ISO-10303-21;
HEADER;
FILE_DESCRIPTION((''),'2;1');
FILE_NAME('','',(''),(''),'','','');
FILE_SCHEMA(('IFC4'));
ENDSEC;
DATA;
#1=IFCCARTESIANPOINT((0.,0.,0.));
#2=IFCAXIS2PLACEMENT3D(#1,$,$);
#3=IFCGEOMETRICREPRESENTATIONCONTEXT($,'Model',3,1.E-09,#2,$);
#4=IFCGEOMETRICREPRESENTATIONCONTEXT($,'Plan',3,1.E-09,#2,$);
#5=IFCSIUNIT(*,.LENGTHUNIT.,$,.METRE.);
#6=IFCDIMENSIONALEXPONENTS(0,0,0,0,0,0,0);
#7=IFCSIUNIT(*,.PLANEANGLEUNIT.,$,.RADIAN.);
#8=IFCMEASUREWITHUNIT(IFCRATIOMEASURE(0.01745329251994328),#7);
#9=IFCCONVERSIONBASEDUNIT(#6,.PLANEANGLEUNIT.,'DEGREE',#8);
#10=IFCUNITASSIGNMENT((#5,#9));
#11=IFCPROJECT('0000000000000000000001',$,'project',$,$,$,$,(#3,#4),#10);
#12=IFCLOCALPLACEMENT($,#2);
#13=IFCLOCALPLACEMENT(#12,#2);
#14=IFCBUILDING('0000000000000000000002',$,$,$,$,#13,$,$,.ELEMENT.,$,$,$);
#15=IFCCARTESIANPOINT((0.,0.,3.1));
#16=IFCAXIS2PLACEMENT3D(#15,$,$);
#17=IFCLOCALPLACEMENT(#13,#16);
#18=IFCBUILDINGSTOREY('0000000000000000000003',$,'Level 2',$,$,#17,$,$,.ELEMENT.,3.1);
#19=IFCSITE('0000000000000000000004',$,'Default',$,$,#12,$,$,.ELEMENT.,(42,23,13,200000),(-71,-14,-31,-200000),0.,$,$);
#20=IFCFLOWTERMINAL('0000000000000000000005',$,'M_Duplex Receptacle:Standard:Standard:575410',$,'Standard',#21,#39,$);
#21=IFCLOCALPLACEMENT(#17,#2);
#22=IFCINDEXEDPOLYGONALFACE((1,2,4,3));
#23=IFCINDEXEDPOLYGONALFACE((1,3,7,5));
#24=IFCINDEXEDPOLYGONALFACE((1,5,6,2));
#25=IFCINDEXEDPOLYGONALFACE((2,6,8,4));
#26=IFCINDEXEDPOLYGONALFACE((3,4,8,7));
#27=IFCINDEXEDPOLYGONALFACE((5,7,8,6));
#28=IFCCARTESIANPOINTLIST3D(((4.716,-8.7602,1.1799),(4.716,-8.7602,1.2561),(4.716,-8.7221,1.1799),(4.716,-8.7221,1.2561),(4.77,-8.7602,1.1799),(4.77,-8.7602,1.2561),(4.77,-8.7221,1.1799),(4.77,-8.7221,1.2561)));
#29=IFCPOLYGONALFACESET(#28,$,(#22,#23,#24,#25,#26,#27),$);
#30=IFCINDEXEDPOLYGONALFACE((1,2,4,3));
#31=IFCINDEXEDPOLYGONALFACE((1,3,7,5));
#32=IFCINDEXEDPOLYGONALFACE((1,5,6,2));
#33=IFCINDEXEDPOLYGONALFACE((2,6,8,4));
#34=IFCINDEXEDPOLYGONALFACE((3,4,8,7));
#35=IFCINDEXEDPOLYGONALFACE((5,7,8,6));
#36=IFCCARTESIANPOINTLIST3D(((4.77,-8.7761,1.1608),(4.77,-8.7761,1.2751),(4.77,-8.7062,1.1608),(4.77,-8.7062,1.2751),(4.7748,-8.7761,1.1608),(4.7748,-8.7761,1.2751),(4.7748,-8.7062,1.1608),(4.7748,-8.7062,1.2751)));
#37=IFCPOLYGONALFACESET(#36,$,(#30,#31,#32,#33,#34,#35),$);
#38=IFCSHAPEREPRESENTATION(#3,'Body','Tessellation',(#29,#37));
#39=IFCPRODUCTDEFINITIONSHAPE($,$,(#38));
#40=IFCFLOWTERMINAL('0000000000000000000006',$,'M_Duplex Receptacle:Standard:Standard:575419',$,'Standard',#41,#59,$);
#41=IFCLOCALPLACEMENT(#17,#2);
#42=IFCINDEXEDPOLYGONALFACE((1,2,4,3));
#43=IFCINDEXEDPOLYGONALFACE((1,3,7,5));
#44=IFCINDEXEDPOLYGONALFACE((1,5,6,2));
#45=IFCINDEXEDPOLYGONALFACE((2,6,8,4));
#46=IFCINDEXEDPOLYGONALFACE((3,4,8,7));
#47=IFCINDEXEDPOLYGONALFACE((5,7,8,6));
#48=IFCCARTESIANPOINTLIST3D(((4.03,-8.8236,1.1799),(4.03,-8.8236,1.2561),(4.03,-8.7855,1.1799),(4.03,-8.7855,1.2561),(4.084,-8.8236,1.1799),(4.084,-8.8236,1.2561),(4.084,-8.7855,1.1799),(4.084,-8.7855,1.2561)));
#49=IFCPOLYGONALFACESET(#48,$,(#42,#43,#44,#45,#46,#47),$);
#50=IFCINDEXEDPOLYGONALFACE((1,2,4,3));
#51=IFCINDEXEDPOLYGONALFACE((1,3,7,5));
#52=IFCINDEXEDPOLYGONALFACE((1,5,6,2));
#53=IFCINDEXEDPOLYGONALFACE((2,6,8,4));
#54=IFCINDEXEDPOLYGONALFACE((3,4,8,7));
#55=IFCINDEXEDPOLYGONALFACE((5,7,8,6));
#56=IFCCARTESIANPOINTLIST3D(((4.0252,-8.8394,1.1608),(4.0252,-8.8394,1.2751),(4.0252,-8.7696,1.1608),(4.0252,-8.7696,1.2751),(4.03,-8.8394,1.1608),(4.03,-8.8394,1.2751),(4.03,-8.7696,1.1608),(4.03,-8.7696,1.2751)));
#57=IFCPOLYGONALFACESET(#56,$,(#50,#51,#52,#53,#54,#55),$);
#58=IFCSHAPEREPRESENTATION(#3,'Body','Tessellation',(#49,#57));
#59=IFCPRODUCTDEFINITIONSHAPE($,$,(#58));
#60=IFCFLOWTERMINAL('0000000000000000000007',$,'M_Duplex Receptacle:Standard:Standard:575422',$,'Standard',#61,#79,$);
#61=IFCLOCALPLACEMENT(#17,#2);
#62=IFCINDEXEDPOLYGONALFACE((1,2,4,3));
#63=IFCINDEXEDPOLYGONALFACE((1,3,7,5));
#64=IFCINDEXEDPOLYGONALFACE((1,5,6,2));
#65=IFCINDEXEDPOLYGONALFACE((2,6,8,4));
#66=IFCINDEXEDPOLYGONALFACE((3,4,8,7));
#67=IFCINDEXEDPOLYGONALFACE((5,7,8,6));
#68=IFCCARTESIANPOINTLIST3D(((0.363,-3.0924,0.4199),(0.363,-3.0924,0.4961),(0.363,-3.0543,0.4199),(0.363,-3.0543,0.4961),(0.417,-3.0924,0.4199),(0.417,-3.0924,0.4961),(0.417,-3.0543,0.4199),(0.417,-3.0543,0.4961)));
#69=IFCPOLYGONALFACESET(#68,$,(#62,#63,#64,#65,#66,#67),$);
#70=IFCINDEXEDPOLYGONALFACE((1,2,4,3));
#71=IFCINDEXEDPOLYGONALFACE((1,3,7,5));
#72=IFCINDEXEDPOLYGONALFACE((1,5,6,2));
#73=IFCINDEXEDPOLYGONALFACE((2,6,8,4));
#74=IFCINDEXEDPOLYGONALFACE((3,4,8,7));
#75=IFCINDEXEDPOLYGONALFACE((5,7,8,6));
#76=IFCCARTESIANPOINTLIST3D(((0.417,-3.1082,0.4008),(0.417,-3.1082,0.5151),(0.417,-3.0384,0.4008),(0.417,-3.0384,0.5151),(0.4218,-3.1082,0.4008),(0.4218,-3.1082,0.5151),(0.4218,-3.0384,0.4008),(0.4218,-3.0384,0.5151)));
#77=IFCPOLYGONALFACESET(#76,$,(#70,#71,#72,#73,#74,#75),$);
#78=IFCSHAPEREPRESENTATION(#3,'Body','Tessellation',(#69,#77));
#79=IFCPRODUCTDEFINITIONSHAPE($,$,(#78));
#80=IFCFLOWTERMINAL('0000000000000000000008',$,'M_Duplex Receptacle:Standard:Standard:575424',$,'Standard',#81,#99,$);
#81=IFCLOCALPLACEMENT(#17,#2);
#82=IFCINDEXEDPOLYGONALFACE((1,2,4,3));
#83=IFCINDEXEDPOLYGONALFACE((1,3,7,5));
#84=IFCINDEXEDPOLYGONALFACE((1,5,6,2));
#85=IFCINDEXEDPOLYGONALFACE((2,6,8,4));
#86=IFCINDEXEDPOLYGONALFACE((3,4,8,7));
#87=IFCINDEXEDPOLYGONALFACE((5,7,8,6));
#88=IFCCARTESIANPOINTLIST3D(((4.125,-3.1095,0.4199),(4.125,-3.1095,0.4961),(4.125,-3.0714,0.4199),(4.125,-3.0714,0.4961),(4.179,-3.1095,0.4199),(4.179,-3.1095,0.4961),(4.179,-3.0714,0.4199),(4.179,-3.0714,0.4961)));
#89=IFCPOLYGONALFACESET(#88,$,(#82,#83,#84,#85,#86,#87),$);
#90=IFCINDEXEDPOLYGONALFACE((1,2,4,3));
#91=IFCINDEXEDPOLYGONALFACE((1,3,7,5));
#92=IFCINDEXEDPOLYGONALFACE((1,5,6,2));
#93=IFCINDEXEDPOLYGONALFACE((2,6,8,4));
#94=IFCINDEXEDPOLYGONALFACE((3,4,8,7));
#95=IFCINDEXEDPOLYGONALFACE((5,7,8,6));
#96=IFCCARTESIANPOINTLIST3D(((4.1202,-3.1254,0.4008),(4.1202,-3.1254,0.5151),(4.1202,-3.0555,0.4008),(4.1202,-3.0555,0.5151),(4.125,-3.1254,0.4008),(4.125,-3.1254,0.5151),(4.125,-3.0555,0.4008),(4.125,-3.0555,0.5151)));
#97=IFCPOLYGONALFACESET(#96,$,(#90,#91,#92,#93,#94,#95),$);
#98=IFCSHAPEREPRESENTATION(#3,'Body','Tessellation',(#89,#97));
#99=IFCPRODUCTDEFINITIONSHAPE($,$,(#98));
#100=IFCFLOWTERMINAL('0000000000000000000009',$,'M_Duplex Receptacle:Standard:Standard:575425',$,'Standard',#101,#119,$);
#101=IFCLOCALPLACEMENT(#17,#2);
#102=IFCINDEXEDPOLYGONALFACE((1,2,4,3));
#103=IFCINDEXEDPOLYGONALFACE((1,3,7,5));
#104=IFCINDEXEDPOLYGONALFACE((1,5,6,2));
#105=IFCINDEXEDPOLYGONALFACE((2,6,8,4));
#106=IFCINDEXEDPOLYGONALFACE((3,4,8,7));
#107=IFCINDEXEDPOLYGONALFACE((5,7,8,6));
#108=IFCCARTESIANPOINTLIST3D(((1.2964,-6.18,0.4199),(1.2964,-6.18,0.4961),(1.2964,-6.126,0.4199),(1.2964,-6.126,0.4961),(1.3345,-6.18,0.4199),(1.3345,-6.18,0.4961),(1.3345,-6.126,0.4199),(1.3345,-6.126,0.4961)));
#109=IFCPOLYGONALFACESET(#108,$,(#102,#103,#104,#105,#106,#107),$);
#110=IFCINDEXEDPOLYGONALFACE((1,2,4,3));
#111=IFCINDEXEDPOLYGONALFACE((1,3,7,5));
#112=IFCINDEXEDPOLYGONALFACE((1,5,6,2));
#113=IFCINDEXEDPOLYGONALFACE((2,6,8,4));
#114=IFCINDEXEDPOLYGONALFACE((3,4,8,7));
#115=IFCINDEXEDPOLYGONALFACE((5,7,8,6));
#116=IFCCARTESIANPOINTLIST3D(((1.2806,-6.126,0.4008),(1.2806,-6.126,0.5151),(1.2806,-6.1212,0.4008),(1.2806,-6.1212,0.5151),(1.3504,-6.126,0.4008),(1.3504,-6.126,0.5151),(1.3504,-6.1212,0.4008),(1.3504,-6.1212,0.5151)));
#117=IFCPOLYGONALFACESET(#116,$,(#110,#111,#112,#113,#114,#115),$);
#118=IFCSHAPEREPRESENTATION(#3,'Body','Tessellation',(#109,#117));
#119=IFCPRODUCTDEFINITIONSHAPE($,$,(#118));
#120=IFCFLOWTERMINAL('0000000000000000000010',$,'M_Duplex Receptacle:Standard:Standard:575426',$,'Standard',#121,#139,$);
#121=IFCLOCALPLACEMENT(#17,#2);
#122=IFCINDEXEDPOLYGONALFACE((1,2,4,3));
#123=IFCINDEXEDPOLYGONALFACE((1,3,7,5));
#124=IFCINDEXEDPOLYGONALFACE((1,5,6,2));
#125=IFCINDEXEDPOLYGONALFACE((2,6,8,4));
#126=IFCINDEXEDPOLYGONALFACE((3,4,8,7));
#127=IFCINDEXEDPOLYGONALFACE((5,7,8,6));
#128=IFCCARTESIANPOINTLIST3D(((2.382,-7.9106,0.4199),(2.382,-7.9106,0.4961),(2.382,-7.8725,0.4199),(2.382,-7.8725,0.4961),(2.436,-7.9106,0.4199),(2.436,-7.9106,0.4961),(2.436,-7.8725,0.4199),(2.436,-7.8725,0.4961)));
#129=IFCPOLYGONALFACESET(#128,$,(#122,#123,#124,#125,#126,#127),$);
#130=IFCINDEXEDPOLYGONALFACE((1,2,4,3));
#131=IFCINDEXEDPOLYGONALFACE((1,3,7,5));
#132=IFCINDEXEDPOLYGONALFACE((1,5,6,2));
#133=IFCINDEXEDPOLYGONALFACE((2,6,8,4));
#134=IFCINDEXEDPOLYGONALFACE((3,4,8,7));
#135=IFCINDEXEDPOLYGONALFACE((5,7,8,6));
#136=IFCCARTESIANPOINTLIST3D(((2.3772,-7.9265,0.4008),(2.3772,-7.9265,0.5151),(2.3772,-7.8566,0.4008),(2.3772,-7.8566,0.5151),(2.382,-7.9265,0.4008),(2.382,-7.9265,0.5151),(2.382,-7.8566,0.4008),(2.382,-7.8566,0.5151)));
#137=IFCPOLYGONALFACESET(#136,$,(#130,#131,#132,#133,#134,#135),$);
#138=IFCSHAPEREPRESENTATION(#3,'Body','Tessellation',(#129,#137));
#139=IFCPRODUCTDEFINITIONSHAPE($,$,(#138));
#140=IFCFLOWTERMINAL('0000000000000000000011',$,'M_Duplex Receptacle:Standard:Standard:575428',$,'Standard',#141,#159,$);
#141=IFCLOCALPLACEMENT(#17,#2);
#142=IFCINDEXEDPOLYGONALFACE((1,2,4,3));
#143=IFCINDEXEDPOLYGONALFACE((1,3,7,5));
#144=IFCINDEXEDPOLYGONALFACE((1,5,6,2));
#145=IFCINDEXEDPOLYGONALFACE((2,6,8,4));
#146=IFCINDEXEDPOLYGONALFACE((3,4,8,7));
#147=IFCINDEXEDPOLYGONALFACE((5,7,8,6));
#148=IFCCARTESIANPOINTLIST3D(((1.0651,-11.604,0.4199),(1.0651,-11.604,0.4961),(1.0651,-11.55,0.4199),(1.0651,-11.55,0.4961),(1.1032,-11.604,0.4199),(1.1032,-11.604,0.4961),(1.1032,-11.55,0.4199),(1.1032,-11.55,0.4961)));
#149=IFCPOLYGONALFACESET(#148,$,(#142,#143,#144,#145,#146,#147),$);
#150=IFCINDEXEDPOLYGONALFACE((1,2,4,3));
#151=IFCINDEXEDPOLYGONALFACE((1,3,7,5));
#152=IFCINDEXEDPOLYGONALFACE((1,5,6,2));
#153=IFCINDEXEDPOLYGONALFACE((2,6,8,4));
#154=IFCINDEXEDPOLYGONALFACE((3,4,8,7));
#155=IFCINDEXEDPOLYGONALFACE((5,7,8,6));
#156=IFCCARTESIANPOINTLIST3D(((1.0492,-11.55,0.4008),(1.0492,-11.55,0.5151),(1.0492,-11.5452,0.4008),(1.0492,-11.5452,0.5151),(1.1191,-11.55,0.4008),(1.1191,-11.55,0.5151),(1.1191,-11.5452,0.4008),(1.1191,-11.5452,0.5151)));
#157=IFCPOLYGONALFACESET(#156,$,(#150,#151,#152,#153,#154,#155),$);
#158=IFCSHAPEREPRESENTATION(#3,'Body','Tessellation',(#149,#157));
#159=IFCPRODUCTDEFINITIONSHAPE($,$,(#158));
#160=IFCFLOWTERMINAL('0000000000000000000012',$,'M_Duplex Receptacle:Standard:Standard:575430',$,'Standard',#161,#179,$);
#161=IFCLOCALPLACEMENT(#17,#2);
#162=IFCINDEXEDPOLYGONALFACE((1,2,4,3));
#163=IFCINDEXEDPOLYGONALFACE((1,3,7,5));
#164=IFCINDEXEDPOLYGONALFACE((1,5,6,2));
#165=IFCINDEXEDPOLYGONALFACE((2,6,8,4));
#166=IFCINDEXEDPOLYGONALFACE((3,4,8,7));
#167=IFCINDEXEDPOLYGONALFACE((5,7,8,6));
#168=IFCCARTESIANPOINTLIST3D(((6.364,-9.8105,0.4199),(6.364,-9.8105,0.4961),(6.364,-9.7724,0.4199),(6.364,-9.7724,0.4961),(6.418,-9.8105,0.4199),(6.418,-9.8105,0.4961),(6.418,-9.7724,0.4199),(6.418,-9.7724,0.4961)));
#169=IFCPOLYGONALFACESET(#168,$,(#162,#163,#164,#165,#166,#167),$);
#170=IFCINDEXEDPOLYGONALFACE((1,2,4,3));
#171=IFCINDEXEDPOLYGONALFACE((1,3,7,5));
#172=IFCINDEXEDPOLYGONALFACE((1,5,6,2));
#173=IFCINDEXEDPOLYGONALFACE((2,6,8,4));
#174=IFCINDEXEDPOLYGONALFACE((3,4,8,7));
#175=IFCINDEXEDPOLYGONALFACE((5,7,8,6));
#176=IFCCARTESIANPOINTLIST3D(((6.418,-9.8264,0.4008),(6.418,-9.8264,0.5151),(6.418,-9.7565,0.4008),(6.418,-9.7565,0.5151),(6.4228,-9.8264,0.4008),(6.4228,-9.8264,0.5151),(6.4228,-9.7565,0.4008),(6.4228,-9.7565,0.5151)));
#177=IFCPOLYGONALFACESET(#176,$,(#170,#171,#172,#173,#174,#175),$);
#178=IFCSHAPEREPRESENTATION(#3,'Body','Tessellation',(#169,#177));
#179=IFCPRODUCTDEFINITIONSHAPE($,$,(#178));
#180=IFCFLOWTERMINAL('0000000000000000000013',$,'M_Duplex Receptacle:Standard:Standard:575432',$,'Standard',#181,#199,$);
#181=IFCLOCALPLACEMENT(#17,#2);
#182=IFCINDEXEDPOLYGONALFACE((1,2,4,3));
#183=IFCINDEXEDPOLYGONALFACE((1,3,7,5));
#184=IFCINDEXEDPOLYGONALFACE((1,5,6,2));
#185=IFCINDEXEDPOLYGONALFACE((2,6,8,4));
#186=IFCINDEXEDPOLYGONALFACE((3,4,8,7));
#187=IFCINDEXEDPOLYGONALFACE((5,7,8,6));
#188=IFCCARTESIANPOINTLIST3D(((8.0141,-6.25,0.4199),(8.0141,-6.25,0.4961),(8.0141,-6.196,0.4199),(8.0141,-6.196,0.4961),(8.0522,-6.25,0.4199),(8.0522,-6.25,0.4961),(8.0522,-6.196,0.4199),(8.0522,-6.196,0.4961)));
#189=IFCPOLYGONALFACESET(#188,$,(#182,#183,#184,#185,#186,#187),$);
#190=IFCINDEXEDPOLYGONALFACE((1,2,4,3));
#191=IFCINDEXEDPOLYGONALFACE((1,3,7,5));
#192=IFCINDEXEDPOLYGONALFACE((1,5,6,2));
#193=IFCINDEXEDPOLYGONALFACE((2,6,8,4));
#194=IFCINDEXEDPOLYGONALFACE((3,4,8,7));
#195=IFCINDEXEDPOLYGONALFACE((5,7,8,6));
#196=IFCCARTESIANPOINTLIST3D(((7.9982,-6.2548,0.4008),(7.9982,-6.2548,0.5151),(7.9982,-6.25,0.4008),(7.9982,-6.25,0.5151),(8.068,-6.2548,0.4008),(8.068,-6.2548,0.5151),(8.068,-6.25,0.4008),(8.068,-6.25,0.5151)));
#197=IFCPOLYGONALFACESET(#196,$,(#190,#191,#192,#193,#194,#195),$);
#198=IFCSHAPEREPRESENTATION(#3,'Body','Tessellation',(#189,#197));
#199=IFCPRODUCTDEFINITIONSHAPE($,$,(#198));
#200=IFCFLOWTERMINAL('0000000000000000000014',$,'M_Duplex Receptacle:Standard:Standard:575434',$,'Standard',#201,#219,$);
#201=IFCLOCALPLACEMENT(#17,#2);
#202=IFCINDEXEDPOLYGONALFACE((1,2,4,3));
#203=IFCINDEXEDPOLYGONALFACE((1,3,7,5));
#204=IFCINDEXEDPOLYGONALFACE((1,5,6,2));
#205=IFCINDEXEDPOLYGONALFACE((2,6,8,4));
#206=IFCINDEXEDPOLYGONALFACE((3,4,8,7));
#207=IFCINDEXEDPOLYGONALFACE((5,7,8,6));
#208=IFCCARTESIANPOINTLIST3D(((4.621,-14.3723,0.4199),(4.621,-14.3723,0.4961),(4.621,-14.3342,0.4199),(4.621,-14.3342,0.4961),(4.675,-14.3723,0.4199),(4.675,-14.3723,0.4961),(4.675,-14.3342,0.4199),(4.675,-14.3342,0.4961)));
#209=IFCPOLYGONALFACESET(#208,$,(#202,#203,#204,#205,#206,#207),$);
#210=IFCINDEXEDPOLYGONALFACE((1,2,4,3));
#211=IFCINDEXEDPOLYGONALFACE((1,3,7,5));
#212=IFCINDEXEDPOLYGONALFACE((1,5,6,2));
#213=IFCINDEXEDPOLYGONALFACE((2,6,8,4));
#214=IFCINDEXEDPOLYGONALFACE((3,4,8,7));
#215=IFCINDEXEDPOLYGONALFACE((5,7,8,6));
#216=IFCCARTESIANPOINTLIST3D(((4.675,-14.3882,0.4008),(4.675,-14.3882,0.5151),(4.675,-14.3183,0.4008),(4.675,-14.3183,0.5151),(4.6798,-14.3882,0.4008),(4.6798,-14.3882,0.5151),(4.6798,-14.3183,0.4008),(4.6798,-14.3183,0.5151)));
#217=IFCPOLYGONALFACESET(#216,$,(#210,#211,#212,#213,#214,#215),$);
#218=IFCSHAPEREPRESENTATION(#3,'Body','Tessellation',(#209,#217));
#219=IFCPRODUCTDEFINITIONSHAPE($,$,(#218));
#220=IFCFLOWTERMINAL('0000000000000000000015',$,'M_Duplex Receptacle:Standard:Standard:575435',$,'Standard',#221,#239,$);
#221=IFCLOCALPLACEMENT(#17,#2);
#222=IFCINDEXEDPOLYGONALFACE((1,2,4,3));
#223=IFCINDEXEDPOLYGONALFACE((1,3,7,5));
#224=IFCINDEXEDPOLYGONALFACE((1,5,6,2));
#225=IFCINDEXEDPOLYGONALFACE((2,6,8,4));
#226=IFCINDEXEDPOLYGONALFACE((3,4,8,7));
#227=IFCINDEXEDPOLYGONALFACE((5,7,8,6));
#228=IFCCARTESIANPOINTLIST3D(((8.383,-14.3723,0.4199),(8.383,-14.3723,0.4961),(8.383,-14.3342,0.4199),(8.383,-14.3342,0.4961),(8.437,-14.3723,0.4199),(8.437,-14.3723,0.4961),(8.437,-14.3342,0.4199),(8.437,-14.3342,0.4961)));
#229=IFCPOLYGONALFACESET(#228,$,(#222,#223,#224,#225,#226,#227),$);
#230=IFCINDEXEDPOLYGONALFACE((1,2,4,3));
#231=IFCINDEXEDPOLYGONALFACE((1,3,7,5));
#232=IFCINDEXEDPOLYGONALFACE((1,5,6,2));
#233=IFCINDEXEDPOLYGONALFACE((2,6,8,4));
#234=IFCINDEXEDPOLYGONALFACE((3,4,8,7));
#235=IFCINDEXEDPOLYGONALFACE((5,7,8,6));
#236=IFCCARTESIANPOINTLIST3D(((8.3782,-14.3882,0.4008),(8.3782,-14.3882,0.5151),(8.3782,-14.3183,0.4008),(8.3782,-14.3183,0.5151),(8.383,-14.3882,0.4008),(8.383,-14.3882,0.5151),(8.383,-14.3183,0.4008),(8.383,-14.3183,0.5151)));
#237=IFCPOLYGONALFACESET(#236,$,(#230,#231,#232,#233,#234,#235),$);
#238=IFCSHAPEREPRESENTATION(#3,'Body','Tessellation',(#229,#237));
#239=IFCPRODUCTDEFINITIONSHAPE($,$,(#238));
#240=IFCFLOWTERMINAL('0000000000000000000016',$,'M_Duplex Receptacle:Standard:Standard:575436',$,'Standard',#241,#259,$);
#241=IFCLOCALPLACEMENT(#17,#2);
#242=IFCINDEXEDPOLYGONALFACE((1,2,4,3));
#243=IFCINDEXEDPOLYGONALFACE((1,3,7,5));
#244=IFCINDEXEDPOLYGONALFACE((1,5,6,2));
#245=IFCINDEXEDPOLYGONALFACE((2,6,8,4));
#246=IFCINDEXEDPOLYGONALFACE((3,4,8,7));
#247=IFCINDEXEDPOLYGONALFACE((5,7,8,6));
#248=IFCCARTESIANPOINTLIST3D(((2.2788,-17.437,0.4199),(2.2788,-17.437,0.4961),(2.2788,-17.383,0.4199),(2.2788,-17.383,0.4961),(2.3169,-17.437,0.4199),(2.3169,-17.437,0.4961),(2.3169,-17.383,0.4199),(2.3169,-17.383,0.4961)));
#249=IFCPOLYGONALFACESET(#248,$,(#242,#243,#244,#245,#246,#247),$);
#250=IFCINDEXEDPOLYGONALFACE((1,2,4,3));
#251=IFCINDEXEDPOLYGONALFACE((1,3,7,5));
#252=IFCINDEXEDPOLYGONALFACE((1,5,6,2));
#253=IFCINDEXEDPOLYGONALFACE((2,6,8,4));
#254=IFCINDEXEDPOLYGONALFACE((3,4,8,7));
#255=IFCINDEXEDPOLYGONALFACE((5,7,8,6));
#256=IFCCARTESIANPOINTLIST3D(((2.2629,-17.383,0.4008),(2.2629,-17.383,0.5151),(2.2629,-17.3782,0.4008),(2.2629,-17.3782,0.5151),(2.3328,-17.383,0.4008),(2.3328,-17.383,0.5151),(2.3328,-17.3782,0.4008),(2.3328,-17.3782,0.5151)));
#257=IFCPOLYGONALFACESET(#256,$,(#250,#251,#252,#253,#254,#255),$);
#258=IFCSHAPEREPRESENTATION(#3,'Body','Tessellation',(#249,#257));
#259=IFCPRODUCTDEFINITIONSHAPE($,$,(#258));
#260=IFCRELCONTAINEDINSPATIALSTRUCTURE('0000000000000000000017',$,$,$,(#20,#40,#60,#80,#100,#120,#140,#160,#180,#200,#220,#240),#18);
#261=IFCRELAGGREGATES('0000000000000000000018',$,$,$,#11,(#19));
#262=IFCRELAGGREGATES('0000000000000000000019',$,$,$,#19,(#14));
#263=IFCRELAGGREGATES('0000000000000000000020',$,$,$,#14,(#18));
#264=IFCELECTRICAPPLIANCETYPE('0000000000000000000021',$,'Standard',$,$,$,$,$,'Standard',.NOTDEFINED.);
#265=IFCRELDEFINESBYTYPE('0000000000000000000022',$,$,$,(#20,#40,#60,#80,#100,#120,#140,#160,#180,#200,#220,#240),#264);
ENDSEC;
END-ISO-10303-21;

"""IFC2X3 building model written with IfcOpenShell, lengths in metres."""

from ifc_helpers import new_model, entity, si_unit, converted_unit, frame, origin, origin_2d_with_axis, place, context, project, spatial, rectangle, extrude, source, transform, mapped, type_object, type_shapes, element, save


model = new_model("IFC2X3")

# Units and contexts
model_context = context("Model", 3, precision=1e-09, world=origin())
plan_context = context("Plan", 3, precision=1e-09, world=origin())
ifc_project = project(units=[si_unit("LENGTHUNIT", "METRE"), converted_unit("PLANEANGLEUNIT", "DEGREE", entity("IfcRatioMeasure", 0.01745329251994328), si_unit("PLANEANGLEUNIT", "RADIAN"), dimensions=[0, 0, 0, 0, 0, 0, 0])], contexts=[model_context, plan_context])

# Site, building, storey
site_placement = place(None, origin())
site = spatial("IfcSite", under=ifc_project, at=site_placement, Name="Default", CompositionType="ELEMENT", RefLatitude=(42, 23, 13, 200000), RefLongitude=(-71, -14, -31, -200000), RefElevation=0.0)
building_placement = place(site_placement, origin())
building = spatial("IfcBuilding", under=site, at=building_placement, CompositionType="ELEMENT")
storey_placement = place(building_placement, frame((0.0, 0.0, 3.1)))
storey = spatial("IfcBuildingStorey", under=building, at=storey_placement, Name="Level 2", CompositionType="ELEMENT", Elevation=3.1)

# Flow terminals
electric_appliance_type_1 = type_object("IfcElectricApplianceType", Name="Standard", ElementType="Standard", PredefinedType="NOTDEFINED")
shared_shape_1 = source(origin(), model_context, "Body", "SweptSolid", [
    extrude(rectangle(XDim=0.0381, YDim=0.0762, at=origin_2d_with_axis()), frame((0.0, 0.0, -0.054), z_axis=(0.0, 0.0, 1.0), x_axis=(-1.0, 0.0, 0.0)), (0.0, 0.0, 1.0), 0.054),
    extrude(rectangle(XDim=0.0698, YDim=0.1143, at=origin_2d_with_axis()), frame((0.0, 0.0, 0.0), z_axis=(0.0, 0.0, 1.0), x_axis=(-1.0, 0.0, 0.0)), (0.0, 0.0, 1.0), 0.0048),
])
type_shapes(electric_appliance_type_1, [shared_shape_1])
for number, where, z_axis, x_axis, name in (
    (1, (4.77, -8.7412, 1.218), (1.0, 0.0, 0.0), (0.0, 1.0, 0.0), "M_Duplex Receptacle:Standard:Standard:575410"),
    (2, (4.03, -8.8045, 1.218), (-1.0, 0.0, 0.0), (0.0, -1.0, 0.0), "M_Duplex Receptacle:Standard:Standard:575419"),
    (3, (0.417, -3.0733, 0.458), (1.0, 0.0, 0.0), (0.0, 1.0, 0.0), "M_Duplex Receptacle:Standard:Standard:575422"),
    (4, (4.125, -3.0905, 0.458), (-1.0, 0.0, 0.0), (0.0, -1.0, 0.0), "M_Duplex Receptacle:Standard:Standard:575424"),
    (5, (1.3155, -6.126, 0.458), (0.0, 1.0, 0.0), (-1.0, 0.0, 0.0), "M_Duplex Receptacle:Standard:Standard:575425"),
    (6, (2.382, -7.8916, 0.458), (-1.0, 0.0, 0.0), (0.0, -1.0, 0.0), "M_Duplex Receptacle:Standard:Standard:575426"),
    (7, (1.0841, -11.55, 0.458), (0.0, 1.0, 0.0), (-1.0, 0.0, 0.0), "M_Duplex Receptacle:Standard:Standard:575428"),
    (8, (6.418, -9.7914, 0.458), (1.0, 0.0, 0.0), (0.0, 1.0, 0.0), "M_Duplex Receptacle:Standard:Standard:575430"),
    (9, (8.0331, -6.25, 0.458), (0.0, -1.0, 0.0), (1.0, 0.0, 0.0), "M_Duplex Receptacle:Standard:Standard:575432"),
    (10, (4.675, -14.3533, 0.458), (1.0, 0.0, 0.0), (0.0, 1.0, 0.0), "M_Duplex Receptacle:Standard:Standard:575434"),
    (11, (8.383, -14.3533, 0.458), (-1.0, 0.0, 0.0), (0.0, -1.0, 0.0), "M_Duplex Receptacle:Standard:Standard:575435"),
    (12, (2.2979, -17.383, 0.458), (0.0, 1.0, 0.0), (-1.0, 0.0, 0.0), "M_Duplex Receptacle:Standard:Standard:575436"),
):
    element("IfcFlowTerminal", number, at=place(storey_placement, frame(where, z_axis=z_axis, x_axis=x_axis)), inside=storey, type_object=electric_appliance_type_1, Name=name, ObjectType="Standard", context=model_context, shape_type="MappedRepresentation", body=[
        mapped(shared_shape_1, transform((0.0, 0.0, 0.0), scale=1.0)),
    ])

save(model, "model.ifc")
